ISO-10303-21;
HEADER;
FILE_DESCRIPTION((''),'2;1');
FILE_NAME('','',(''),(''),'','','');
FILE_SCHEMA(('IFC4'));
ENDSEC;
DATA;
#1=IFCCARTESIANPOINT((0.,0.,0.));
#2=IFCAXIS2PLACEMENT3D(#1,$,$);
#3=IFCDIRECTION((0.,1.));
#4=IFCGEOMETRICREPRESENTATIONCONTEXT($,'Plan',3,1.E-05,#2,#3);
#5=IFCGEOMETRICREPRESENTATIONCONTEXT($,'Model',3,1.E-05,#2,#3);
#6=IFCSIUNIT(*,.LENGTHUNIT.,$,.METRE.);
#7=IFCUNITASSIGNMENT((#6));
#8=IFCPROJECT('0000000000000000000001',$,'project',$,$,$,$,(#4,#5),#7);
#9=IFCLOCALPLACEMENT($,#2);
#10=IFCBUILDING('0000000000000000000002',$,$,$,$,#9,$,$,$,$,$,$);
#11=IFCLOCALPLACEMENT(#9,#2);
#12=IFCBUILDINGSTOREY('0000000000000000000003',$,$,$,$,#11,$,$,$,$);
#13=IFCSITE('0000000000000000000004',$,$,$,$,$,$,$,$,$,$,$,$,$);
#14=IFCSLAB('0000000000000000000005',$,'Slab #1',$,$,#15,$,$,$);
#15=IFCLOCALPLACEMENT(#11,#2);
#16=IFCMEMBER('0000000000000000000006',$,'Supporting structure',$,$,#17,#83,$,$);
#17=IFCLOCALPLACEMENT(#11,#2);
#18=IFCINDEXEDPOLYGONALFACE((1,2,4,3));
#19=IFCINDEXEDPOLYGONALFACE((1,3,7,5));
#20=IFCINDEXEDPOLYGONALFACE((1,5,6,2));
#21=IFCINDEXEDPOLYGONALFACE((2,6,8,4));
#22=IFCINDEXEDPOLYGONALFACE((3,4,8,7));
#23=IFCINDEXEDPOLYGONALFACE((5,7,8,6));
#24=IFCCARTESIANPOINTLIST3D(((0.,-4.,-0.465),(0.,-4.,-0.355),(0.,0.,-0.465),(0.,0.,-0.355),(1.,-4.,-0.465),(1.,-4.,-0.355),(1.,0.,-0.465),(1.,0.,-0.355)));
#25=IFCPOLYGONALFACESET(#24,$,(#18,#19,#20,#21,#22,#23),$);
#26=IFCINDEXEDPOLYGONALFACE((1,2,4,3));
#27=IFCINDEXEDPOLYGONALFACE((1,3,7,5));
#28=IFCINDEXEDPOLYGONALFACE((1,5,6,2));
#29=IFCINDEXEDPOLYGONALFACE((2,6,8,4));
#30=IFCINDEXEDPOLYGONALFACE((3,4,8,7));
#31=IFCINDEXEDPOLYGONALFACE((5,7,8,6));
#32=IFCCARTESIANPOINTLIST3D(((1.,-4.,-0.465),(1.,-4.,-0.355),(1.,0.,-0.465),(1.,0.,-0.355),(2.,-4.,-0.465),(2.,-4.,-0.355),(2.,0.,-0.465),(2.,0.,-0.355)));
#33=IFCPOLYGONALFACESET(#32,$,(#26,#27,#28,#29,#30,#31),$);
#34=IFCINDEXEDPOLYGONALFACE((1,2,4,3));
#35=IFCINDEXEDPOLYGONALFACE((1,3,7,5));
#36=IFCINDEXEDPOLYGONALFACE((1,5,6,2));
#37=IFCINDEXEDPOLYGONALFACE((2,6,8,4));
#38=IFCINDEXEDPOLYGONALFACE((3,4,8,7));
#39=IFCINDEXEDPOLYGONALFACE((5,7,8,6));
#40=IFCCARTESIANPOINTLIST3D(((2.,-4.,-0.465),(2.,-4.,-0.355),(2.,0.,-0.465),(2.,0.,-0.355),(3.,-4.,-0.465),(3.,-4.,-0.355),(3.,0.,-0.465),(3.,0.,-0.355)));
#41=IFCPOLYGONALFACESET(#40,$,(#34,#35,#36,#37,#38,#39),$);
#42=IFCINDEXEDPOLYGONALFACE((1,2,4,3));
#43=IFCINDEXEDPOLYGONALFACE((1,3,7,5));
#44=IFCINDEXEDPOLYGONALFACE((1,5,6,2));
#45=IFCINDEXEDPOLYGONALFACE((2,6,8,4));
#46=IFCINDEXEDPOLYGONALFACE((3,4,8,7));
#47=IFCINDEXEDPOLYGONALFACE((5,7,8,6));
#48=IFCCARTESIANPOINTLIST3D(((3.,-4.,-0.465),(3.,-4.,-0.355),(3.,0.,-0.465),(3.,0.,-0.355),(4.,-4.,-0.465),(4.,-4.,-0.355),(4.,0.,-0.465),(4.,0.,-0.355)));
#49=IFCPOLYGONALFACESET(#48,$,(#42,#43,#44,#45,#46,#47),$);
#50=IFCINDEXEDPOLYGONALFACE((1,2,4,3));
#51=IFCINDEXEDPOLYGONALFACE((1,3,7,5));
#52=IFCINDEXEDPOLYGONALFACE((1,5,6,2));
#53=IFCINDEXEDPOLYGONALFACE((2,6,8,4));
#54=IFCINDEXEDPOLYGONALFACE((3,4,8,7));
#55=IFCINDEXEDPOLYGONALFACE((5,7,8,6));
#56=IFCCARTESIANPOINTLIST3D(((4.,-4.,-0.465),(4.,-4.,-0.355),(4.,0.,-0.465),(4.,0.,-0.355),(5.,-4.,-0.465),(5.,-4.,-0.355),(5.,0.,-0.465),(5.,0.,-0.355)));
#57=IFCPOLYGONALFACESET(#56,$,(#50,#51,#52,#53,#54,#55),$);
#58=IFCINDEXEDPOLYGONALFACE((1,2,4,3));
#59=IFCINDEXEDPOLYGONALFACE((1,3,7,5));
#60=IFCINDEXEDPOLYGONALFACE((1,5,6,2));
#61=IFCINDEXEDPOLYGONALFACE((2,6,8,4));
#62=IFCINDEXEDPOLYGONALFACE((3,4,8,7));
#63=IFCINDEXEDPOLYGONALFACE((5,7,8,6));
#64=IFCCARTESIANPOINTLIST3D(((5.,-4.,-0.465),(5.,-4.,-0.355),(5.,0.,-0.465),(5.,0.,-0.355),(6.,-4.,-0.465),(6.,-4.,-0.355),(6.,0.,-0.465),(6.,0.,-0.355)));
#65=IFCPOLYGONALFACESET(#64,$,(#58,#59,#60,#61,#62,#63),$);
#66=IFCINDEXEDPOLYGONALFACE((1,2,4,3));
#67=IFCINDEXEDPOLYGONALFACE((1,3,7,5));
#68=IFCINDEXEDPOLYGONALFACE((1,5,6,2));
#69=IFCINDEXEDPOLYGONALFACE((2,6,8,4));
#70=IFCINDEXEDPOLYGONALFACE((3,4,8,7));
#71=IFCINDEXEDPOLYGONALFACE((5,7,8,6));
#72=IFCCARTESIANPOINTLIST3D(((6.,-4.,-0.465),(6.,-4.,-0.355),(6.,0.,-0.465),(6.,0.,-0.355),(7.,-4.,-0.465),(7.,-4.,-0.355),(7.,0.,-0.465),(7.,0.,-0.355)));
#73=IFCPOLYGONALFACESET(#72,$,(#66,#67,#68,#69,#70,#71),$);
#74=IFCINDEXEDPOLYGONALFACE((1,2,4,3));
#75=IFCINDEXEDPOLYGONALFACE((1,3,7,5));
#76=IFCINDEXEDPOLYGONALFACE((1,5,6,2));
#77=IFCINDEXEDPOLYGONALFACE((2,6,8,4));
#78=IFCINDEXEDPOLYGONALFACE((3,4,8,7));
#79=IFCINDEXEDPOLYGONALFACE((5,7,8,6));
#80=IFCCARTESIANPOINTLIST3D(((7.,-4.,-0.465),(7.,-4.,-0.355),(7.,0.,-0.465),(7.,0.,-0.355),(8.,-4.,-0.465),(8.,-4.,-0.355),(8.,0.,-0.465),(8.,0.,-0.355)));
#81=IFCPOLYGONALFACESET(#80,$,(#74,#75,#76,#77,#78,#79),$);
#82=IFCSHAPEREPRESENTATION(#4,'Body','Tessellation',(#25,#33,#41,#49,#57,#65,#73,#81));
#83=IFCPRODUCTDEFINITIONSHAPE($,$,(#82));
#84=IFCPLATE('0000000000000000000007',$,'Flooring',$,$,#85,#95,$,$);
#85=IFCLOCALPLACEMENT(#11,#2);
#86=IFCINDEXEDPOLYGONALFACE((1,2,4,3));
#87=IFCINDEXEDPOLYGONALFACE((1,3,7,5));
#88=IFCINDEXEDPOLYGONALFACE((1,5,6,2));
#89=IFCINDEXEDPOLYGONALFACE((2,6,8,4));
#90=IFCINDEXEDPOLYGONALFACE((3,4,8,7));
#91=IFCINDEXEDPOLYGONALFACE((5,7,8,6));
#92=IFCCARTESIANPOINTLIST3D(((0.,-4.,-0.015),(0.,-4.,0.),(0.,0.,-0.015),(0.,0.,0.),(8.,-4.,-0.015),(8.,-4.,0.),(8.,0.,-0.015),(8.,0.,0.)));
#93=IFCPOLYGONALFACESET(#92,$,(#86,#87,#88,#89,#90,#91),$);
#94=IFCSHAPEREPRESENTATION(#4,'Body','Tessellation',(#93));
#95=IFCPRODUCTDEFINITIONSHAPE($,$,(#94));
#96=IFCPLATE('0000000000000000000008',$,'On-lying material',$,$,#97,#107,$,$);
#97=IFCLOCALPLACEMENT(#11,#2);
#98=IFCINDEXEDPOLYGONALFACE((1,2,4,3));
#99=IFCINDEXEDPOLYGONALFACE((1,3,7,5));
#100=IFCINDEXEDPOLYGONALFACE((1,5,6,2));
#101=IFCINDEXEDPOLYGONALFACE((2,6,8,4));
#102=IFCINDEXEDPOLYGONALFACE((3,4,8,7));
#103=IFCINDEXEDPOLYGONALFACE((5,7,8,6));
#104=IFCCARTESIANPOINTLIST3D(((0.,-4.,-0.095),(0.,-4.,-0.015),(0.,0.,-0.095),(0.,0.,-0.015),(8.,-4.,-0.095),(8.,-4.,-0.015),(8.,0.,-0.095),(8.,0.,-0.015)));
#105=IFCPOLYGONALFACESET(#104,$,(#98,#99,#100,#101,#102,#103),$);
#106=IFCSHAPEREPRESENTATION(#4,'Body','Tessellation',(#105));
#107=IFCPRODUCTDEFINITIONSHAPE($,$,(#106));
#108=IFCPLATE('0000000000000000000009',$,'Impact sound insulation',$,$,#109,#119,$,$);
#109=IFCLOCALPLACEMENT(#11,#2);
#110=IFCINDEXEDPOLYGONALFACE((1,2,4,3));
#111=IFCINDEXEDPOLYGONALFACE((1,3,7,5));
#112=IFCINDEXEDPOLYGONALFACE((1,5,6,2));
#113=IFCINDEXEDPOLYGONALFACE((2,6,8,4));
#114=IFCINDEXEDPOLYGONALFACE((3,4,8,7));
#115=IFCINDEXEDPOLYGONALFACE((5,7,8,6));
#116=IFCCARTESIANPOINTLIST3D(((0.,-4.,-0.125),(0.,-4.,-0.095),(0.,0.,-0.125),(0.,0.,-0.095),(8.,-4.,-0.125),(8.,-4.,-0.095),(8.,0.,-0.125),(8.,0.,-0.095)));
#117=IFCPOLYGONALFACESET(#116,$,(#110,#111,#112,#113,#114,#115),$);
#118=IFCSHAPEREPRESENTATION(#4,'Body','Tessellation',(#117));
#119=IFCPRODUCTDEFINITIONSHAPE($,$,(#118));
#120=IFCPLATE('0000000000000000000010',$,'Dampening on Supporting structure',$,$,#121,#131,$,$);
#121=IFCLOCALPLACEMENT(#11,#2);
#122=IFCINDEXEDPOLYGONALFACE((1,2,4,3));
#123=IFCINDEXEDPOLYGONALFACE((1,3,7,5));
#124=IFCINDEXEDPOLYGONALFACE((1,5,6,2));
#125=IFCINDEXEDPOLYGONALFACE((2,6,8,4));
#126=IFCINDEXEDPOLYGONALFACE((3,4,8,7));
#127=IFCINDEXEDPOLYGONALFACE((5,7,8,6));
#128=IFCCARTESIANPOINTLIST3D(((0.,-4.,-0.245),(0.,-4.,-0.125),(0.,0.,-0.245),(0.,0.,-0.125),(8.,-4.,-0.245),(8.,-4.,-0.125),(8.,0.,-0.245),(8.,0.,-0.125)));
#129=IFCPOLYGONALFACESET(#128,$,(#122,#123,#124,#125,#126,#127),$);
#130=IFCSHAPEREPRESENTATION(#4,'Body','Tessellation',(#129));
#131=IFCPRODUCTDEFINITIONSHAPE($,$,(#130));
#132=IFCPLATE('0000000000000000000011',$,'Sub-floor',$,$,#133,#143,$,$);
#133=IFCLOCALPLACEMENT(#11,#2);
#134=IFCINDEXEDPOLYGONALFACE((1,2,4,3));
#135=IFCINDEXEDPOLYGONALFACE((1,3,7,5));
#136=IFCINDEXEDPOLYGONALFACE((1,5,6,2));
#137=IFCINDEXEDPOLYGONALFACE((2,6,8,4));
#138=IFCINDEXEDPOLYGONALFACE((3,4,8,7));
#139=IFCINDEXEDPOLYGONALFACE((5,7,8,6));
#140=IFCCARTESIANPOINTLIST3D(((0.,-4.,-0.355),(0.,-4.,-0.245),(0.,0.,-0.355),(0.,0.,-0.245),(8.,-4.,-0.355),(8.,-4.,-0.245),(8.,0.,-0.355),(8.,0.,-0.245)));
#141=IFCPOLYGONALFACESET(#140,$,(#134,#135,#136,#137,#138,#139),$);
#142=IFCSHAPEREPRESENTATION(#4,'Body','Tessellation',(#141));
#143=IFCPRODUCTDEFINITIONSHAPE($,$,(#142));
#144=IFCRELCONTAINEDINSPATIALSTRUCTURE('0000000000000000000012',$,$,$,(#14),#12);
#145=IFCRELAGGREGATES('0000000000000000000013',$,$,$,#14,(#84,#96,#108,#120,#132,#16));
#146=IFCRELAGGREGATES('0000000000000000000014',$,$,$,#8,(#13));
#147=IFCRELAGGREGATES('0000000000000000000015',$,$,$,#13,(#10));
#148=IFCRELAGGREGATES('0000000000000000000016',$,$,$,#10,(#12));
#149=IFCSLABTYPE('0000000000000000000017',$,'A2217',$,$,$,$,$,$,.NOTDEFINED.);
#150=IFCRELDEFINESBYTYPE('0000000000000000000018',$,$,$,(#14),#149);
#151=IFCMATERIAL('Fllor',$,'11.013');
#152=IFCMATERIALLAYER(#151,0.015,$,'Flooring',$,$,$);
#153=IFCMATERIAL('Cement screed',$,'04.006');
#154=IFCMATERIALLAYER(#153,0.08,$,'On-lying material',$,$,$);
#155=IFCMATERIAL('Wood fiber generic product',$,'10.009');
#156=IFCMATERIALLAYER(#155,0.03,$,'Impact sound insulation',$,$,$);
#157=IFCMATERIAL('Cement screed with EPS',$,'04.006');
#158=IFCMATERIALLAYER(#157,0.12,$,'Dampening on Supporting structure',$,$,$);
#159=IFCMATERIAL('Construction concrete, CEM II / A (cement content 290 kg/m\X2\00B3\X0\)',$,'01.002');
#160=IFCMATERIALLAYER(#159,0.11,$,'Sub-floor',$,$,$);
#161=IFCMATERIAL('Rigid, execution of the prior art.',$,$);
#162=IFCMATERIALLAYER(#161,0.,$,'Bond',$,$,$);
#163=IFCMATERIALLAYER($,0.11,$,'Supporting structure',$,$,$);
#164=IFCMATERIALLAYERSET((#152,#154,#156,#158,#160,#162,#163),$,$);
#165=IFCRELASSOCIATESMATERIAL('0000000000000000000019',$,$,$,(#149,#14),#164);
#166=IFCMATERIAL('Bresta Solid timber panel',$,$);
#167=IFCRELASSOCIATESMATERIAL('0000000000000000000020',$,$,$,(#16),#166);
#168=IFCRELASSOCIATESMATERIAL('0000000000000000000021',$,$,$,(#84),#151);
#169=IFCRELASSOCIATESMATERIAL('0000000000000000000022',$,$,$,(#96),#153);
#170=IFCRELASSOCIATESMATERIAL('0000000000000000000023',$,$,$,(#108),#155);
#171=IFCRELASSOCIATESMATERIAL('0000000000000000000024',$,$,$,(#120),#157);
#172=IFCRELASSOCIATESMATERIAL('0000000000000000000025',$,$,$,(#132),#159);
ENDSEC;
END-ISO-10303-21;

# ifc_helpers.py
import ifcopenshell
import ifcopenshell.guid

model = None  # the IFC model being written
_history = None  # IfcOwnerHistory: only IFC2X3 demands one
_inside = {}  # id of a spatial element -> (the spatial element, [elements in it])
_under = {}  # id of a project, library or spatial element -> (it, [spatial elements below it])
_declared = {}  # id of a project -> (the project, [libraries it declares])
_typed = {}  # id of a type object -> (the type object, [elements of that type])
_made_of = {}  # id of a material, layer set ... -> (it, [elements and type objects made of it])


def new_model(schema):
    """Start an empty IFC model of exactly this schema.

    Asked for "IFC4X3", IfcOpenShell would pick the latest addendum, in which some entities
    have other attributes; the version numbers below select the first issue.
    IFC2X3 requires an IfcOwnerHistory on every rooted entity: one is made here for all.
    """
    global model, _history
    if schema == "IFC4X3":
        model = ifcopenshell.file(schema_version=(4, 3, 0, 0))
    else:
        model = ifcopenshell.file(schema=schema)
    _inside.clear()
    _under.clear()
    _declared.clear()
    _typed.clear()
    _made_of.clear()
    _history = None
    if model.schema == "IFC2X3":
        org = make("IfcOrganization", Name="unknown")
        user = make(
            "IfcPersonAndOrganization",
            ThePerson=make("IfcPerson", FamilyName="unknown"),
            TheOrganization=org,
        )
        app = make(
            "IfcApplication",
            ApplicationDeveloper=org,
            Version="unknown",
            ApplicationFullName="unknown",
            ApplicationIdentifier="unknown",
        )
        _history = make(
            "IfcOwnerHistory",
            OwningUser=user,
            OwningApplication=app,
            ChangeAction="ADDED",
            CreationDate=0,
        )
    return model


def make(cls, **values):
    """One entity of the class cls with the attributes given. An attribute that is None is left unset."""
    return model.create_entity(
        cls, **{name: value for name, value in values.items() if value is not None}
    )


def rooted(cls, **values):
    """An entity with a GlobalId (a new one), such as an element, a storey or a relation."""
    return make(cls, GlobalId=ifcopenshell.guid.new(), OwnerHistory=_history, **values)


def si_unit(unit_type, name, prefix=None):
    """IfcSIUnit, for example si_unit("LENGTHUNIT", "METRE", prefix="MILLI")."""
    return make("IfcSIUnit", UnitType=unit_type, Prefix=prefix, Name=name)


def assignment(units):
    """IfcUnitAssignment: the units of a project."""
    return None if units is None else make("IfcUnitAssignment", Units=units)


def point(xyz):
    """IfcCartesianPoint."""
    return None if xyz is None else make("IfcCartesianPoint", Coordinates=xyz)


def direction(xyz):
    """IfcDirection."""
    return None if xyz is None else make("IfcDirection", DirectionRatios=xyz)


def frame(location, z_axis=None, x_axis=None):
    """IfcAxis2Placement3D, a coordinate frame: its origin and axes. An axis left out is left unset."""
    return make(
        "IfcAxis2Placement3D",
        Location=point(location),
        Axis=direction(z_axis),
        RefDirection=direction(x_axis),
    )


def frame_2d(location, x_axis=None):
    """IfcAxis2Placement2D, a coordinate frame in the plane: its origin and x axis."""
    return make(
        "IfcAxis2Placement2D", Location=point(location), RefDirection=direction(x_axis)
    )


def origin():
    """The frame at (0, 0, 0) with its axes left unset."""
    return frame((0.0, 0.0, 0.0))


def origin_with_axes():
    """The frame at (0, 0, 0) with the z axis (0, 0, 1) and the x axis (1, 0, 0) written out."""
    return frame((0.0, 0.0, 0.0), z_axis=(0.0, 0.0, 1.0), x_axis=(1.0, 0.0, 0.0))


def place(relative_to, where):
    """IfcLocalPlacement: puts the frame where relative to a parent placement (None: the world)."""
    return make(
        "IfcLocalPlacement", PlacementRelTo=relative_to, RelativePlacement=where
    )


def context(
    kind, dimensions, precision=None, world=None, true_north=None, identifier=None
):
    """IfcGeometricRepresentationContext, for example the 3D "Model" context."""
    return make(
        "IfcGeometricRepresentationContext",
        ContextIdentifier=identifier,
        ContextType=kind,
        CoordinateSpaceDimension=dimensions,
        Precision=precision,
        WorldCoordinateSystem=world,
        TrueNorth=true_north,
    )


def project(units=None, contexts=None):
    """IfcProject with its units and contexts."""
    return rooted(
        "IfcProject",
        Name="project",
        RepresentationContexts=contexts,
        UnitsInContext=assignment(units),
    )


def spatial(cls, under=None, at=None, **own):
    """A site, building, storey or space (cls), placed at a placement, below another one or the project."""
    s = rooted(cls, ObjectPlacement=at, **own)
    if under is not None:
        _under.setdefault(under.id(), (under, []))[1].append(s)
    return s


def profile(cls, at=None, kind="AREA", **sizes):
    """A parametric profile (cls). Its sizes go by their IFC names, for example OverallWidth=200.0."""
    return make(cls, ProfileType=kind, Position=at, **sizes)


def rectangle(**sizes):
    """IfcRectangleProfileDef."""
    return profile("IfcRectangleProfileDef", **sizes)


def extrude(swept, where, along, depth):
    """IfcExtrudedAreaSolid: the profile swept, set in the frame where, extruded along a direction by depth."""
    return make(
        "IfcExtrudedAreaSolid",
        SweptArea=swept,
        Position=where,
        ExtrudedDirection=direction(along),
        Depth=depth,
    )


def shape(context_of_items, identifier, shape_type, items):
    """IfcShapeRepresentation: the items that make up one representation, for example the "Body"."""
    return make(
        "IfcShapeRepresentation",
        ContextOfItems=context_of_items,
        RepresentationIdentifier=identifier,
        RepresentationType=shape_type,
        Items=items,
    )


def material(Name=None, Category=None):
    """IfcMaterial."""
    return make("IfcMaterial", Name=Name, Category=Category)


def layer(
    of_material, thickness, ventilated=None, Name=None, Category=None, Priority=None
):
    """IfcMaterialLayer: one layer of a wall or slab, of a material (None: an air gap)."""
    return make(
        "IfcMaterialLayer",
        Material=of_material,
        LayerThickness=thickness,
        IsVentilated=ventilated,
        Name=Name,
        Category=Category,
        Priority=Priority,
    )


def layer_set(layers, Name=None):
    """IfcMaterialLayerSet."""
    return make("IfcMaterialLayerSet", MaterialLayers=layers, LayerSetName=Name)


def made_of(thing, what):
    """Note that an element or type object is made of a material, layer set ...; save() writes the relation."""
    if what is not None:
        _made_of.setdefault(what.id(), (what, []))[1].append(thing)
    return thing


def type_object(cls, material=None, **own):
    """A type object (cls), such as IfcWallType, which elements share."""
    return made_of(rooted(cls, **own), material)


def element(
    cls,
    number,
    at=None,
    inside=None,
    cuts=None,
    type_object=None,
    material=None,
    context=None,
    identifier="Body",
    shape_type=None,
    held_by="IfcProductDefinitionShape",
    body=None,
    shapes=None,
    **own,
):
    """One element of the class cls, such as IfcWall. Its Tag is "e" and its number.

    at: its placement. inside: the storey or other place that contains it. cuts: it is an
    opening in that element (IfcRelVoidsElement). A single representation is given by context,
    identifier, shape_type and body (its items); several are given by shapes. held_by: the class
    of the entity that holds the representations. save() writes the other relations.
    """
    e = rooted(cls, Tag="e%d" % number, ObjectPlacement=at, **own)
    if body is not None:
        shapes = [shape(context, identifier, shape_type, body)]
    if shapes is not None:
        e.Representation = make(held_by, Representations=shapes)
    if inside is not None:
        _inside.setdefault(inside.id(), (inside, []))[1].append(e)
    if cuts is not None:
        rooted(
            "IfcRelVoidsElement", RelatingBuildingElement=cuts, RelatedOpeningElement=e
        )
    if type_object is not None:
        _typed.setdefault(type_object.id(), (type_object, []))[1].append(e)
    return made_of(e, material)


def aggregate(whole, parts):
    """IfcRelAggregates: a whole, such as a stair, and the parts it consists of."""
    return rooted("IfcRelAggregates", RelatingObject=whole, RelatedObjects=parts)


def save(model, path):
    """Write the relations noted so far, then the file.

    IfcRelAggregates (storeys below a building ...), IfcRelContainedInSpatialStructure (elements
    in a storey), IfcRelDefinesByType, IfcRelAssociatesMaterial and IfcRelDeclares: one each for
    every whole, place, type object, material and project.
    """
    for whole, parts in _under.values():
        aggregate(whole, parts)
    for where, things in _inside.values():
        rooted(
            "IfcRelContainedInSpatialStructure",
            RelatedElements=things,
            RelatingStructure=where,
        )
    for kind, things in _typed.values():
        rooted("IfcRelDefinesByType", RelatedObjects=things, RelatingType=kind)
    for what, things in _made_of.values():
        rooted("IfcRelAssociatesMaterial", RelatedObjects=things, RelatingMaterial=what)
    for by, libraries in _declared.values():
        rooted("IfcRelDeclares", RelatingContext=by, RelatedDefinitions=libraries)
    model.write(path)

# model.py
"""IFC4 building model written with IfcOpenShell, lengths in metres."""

from ifc_helpers import new_model, si_unit, direction, frame, frame_2d, origin, origin_with_axes, place, context, project, spatial, rectangle, extrude, material, layer, layer_set, type_object, element, aggregate, save


model = new_model("IFC4")

# Units and contexts
plan_context = context("Plan", 3, precision=1e-05, world=origin(), true_north=direction((0.0, 1.0)))
model_context = context("Model", 3, precision=1e-05, world=origin(), true_north=direction((0.0, 1.0)))
ifc_project = project(units=[si_unit("LENGTHUNIT", "METRE")], contexts=[plan_context, model_context])

# Site, building, storey
site = spatial("IfcSite", under=ifc_project)
building_placement = place(None, origin())
building = spatial("IfcBuilding", under=site, at=building_placement)
storey_placement = place(building_placement, origin())
storey = spatial("IfcBuildingStorey", under=building, at=storey_placement)

# Slab, member, plates
ifc_material_1 = material(Name="Fllor", Category="11.013")
ifc_layer_1 = layer(ifc_material_1, 0.015, Name="Flooring")
ifc_material_2 = material(Name="Cement screed", Category="04.006")
ifc_layer_2 = layer(ifc_material_2, 0.08, Name="On-lying material")
ifc_material_3 = material(Name="Wood fiber generic product", Category="10.009")
ifc_layer_3 = layer(ifc_material_3, 0.03, Name="Impact sound insulation")
ifc_material_4 = material(Name="Cement screed with EPS", Category="04.006")
ifc_layer_4 = layer(ifc_material_4, 0.12, Name="Dampening on Supporting structure")
ifc_material_5 = material(Name="Construction concrete, CEM II / A (cement content 290 kg/m³)", Category="01.002")
ifc_layer_5 = layer(ifc_material_5, 0.11, Name="Sub-floor")
ifc_material_6 = material(Name="Rigid, execution of the prior art.")
ifc_layer_6 = layer(ifc_material_6, 0.0, Name="Bond")
ifc_layer_7 = layer(None, 0.11, Name="Supporting structure")
ifc_layer_set = layer_set([ifc_layer_1, ifc_layer_2, ifc_layer_3, ifc_layer_4, ifc_layer_5, ifc_layer_6, ifc_layer_7])
slab_type = type_object("IfcSlabType", Name="A2217", PredefinedType="NOTDEFINED", material=ifc_layer_set)
slab_placement = place(None, frame((0.0, 0.0, 0.0), z_axis=(0.0, 0.0, -1.0), x_axis=(1.0, 0.0, 0.0)))
slab = element("IfcSlab", 1, at=slab_placement, inside=storey, type_object=slab_type, material=ifc_layer_set, Name="Slab #1")
ifc_material_7 = material(Name="Bresta Solid timber panel")
member_placement = place(slab_placement, origin())
member = element("IfcMember", 2, at=member_placement, material=ifc_material_7, Name="Supporting structure", context=plan_context, shape_type="SweptSolid", body=[
    extrude(rectangle(XDim=1.0, YDim=0.11, at=frame_2d((0.5, 0.055), x_axis=(1.0, 0.0))), frame((0.0, 4.0, 0.355), z_axis=(0.0, -1.0, 0.0), x_axis=(1.0, 0.0, 0.0)), (0.0, 0.0, 1.0), 4.0),
    extrude(rectangle(XDim=1.0, YDim=0.11, at=frame_2d((0.5, 0.055), x_axis=(1.0, 0.0))), frame((1.0, 4.0, 0.355), z_axis=(0.0, -1.0, 0.0), x_axis=(1.0, 0.0, 0.0)), (0.0, 0.0, 1.0), 4.0),
    extrude(rectangle(XDim=1.0, YDim=0.11, at=frame_2d((0.5, 0.055), x_axis=(1.0, 0.0))), frame((2.0, 4.0, 0.355), z_axis=(0.0, -1.0, 0.0), x_axis=(1.0, 0.0, 0.0)), (0.0, 0.0, 1.0), 4.0),
    extrude(rectangle(XDim=1.0, YDim=0.11, at=frame_2d((0.5, 0.055), x_axis=(1.0, 0.0))), frame((3.0, 4.0, 0.355), z_axis=(0.0, -1.0, 0.0), x_axis=(1.0, 0.0, 0.0)), (0.0, 0.0, 1.0), 4.0),
    extrude(rectangle(XDim=1.0, YDim=0.11, at=frame_2d((0.5, 0.055), x_axis=(1.0, 0.0))), frame((4.0, 4.0, 0.355), z_axis=(0.0, -1.0, 0.0), x_axis=(1.0, 0.0, 0.0)), (0.0, 0.0, 1.0), 4.0),
    extrude(rectangle(XDim=1.0, YDim=0.11, at=frame_2d((0.5, 0.055), x_axis=(1.0, 0.0))), frame((5.0, 4.0, 0.355), z_axis=(0.0, -1.0, 0.0), x_axis=(1.0, 0.0, 0.0)), (0.0, 0.0, 1.0), 4.0),
    extrude(rectangle(XDim=1.0, YDim=0.11, at=frame_2d((0.5, 0.055), x_axis=(1.0, 0.0))), frame((6.0, 4.0, 0.355), z_axis=(0.0, -1.0, 0.0), x_axis=(1.0, 0.0, 0.0)), (0.0, 0.0, 1.0), 4.0),
    extrude(rectangle(XDim=1.0, YDim=0.11, at=frame_2d((0.5, 0.055), x_axis=(1.0, 0.0))), frame((7.0, 4.0, 0.355), z_axis=(0.0, -1.0, 0.0), x_axis=(1.0, 0.0, 0.0)), (0.0, 0.0, 1.0), 4.0),
])
plate_1_placement = place(slab_placement, origin())
plate_1 = element("IfcPlate", 3, at=plate_1_placement, material=ifc_material_1, Name="Flooring", context=plan_context, shape_type="SweptSolid", body=[
    extrude(rectangle(XDim=8.0, YDim=4.0, at=frame_2d((4.0, 2.0), x_axis=(1.0, 0.0))), origin_with_axes(), (0.0, 0.0, 1.0), 0.015),
])
plate_2_placement = place(slab_placement, origin())
plate_2 = element("IfcPlate", 4, at=plate_2_placement, material=ifc_material_2, Name="On-lying material", context=plan_context, shape_type="SweptSolid", body=[
    extrude(rectangle(XDim=8.0, YDim=4.0, at=frame_2d((4.0, 2.0), x_axis=(1.0, 0.0))), frame((0.0, 0.0, 0.015), z_axis=(0.0, 0.0, 1.0), x_axis=(1.0, 0.0, 0.0)), (0.0, 0.0, 1.0), 0.08),
])
plate_3_placement = place(slab_placement, origin())
plate_3 = element("IfcPlate", 5, at=plate_3_placement, material=ifc_material_3, Name="Impact sound insulation", context=plan_context, shape_type="SweptSolid", body=[
    extrude(rectangle(XDim=8.0, YDim=4.0, at=frame_2d((4.0, 2.0), x_axis=(1.0, 0.0))), frame((0.0, 0.0, 0.095), z_axis=(0.0, 0.0, 1.0), x_axis=(1.0, 0.0, 0.0)), (0.0, 0.0, 1.0), 0.03),
])
plate_4_placement = place(slab_placement, origin())
plate_4 = element("IfcPlate", 6, at=plate_4_placement, material=ifc_material_4, Name="Dampening on Supporting structure", context=plan_context, shape_type="SweptSolid", body=[
    extrude(rectangle(XDim=8.0, YDim=4.0, at=frame_2d((4.0, 2.0), x_axis=(1.0, 0.0))), frame((0.0, 0.0, 0.125), z_axis=(0.0, 0.0, 1.0), x_axis=(1.0, 0.0, 0.0)), (0.0, 0.0, 1.0), 0.12),
])
plate_5_placement = place(slab_placement, origin())
plate_5 = element("IfcPlate", 7, at=plate_5_placement, material=ifc_material_5, Name="Sub-floor", context=plan_context, shape_type="SweptSolid", body=[
    extrude(rectangle(XDim=8.0, YDim=4.0, at=frame_2d((4.0, 2.0), x_axis=(1.0, 0.0))), frame((0.0, 0.0, 0.245), z_axis=(0.0, 0.0, 1.0), x_axis=(1.0, 0.0, 0.0)), (0.0, 0.0, 1.0), 0.11),
])
aggregate(slab, [plate_1, plate_2, plate_3, plate_4, plate_5, member])

save(model, "model.ifc")
